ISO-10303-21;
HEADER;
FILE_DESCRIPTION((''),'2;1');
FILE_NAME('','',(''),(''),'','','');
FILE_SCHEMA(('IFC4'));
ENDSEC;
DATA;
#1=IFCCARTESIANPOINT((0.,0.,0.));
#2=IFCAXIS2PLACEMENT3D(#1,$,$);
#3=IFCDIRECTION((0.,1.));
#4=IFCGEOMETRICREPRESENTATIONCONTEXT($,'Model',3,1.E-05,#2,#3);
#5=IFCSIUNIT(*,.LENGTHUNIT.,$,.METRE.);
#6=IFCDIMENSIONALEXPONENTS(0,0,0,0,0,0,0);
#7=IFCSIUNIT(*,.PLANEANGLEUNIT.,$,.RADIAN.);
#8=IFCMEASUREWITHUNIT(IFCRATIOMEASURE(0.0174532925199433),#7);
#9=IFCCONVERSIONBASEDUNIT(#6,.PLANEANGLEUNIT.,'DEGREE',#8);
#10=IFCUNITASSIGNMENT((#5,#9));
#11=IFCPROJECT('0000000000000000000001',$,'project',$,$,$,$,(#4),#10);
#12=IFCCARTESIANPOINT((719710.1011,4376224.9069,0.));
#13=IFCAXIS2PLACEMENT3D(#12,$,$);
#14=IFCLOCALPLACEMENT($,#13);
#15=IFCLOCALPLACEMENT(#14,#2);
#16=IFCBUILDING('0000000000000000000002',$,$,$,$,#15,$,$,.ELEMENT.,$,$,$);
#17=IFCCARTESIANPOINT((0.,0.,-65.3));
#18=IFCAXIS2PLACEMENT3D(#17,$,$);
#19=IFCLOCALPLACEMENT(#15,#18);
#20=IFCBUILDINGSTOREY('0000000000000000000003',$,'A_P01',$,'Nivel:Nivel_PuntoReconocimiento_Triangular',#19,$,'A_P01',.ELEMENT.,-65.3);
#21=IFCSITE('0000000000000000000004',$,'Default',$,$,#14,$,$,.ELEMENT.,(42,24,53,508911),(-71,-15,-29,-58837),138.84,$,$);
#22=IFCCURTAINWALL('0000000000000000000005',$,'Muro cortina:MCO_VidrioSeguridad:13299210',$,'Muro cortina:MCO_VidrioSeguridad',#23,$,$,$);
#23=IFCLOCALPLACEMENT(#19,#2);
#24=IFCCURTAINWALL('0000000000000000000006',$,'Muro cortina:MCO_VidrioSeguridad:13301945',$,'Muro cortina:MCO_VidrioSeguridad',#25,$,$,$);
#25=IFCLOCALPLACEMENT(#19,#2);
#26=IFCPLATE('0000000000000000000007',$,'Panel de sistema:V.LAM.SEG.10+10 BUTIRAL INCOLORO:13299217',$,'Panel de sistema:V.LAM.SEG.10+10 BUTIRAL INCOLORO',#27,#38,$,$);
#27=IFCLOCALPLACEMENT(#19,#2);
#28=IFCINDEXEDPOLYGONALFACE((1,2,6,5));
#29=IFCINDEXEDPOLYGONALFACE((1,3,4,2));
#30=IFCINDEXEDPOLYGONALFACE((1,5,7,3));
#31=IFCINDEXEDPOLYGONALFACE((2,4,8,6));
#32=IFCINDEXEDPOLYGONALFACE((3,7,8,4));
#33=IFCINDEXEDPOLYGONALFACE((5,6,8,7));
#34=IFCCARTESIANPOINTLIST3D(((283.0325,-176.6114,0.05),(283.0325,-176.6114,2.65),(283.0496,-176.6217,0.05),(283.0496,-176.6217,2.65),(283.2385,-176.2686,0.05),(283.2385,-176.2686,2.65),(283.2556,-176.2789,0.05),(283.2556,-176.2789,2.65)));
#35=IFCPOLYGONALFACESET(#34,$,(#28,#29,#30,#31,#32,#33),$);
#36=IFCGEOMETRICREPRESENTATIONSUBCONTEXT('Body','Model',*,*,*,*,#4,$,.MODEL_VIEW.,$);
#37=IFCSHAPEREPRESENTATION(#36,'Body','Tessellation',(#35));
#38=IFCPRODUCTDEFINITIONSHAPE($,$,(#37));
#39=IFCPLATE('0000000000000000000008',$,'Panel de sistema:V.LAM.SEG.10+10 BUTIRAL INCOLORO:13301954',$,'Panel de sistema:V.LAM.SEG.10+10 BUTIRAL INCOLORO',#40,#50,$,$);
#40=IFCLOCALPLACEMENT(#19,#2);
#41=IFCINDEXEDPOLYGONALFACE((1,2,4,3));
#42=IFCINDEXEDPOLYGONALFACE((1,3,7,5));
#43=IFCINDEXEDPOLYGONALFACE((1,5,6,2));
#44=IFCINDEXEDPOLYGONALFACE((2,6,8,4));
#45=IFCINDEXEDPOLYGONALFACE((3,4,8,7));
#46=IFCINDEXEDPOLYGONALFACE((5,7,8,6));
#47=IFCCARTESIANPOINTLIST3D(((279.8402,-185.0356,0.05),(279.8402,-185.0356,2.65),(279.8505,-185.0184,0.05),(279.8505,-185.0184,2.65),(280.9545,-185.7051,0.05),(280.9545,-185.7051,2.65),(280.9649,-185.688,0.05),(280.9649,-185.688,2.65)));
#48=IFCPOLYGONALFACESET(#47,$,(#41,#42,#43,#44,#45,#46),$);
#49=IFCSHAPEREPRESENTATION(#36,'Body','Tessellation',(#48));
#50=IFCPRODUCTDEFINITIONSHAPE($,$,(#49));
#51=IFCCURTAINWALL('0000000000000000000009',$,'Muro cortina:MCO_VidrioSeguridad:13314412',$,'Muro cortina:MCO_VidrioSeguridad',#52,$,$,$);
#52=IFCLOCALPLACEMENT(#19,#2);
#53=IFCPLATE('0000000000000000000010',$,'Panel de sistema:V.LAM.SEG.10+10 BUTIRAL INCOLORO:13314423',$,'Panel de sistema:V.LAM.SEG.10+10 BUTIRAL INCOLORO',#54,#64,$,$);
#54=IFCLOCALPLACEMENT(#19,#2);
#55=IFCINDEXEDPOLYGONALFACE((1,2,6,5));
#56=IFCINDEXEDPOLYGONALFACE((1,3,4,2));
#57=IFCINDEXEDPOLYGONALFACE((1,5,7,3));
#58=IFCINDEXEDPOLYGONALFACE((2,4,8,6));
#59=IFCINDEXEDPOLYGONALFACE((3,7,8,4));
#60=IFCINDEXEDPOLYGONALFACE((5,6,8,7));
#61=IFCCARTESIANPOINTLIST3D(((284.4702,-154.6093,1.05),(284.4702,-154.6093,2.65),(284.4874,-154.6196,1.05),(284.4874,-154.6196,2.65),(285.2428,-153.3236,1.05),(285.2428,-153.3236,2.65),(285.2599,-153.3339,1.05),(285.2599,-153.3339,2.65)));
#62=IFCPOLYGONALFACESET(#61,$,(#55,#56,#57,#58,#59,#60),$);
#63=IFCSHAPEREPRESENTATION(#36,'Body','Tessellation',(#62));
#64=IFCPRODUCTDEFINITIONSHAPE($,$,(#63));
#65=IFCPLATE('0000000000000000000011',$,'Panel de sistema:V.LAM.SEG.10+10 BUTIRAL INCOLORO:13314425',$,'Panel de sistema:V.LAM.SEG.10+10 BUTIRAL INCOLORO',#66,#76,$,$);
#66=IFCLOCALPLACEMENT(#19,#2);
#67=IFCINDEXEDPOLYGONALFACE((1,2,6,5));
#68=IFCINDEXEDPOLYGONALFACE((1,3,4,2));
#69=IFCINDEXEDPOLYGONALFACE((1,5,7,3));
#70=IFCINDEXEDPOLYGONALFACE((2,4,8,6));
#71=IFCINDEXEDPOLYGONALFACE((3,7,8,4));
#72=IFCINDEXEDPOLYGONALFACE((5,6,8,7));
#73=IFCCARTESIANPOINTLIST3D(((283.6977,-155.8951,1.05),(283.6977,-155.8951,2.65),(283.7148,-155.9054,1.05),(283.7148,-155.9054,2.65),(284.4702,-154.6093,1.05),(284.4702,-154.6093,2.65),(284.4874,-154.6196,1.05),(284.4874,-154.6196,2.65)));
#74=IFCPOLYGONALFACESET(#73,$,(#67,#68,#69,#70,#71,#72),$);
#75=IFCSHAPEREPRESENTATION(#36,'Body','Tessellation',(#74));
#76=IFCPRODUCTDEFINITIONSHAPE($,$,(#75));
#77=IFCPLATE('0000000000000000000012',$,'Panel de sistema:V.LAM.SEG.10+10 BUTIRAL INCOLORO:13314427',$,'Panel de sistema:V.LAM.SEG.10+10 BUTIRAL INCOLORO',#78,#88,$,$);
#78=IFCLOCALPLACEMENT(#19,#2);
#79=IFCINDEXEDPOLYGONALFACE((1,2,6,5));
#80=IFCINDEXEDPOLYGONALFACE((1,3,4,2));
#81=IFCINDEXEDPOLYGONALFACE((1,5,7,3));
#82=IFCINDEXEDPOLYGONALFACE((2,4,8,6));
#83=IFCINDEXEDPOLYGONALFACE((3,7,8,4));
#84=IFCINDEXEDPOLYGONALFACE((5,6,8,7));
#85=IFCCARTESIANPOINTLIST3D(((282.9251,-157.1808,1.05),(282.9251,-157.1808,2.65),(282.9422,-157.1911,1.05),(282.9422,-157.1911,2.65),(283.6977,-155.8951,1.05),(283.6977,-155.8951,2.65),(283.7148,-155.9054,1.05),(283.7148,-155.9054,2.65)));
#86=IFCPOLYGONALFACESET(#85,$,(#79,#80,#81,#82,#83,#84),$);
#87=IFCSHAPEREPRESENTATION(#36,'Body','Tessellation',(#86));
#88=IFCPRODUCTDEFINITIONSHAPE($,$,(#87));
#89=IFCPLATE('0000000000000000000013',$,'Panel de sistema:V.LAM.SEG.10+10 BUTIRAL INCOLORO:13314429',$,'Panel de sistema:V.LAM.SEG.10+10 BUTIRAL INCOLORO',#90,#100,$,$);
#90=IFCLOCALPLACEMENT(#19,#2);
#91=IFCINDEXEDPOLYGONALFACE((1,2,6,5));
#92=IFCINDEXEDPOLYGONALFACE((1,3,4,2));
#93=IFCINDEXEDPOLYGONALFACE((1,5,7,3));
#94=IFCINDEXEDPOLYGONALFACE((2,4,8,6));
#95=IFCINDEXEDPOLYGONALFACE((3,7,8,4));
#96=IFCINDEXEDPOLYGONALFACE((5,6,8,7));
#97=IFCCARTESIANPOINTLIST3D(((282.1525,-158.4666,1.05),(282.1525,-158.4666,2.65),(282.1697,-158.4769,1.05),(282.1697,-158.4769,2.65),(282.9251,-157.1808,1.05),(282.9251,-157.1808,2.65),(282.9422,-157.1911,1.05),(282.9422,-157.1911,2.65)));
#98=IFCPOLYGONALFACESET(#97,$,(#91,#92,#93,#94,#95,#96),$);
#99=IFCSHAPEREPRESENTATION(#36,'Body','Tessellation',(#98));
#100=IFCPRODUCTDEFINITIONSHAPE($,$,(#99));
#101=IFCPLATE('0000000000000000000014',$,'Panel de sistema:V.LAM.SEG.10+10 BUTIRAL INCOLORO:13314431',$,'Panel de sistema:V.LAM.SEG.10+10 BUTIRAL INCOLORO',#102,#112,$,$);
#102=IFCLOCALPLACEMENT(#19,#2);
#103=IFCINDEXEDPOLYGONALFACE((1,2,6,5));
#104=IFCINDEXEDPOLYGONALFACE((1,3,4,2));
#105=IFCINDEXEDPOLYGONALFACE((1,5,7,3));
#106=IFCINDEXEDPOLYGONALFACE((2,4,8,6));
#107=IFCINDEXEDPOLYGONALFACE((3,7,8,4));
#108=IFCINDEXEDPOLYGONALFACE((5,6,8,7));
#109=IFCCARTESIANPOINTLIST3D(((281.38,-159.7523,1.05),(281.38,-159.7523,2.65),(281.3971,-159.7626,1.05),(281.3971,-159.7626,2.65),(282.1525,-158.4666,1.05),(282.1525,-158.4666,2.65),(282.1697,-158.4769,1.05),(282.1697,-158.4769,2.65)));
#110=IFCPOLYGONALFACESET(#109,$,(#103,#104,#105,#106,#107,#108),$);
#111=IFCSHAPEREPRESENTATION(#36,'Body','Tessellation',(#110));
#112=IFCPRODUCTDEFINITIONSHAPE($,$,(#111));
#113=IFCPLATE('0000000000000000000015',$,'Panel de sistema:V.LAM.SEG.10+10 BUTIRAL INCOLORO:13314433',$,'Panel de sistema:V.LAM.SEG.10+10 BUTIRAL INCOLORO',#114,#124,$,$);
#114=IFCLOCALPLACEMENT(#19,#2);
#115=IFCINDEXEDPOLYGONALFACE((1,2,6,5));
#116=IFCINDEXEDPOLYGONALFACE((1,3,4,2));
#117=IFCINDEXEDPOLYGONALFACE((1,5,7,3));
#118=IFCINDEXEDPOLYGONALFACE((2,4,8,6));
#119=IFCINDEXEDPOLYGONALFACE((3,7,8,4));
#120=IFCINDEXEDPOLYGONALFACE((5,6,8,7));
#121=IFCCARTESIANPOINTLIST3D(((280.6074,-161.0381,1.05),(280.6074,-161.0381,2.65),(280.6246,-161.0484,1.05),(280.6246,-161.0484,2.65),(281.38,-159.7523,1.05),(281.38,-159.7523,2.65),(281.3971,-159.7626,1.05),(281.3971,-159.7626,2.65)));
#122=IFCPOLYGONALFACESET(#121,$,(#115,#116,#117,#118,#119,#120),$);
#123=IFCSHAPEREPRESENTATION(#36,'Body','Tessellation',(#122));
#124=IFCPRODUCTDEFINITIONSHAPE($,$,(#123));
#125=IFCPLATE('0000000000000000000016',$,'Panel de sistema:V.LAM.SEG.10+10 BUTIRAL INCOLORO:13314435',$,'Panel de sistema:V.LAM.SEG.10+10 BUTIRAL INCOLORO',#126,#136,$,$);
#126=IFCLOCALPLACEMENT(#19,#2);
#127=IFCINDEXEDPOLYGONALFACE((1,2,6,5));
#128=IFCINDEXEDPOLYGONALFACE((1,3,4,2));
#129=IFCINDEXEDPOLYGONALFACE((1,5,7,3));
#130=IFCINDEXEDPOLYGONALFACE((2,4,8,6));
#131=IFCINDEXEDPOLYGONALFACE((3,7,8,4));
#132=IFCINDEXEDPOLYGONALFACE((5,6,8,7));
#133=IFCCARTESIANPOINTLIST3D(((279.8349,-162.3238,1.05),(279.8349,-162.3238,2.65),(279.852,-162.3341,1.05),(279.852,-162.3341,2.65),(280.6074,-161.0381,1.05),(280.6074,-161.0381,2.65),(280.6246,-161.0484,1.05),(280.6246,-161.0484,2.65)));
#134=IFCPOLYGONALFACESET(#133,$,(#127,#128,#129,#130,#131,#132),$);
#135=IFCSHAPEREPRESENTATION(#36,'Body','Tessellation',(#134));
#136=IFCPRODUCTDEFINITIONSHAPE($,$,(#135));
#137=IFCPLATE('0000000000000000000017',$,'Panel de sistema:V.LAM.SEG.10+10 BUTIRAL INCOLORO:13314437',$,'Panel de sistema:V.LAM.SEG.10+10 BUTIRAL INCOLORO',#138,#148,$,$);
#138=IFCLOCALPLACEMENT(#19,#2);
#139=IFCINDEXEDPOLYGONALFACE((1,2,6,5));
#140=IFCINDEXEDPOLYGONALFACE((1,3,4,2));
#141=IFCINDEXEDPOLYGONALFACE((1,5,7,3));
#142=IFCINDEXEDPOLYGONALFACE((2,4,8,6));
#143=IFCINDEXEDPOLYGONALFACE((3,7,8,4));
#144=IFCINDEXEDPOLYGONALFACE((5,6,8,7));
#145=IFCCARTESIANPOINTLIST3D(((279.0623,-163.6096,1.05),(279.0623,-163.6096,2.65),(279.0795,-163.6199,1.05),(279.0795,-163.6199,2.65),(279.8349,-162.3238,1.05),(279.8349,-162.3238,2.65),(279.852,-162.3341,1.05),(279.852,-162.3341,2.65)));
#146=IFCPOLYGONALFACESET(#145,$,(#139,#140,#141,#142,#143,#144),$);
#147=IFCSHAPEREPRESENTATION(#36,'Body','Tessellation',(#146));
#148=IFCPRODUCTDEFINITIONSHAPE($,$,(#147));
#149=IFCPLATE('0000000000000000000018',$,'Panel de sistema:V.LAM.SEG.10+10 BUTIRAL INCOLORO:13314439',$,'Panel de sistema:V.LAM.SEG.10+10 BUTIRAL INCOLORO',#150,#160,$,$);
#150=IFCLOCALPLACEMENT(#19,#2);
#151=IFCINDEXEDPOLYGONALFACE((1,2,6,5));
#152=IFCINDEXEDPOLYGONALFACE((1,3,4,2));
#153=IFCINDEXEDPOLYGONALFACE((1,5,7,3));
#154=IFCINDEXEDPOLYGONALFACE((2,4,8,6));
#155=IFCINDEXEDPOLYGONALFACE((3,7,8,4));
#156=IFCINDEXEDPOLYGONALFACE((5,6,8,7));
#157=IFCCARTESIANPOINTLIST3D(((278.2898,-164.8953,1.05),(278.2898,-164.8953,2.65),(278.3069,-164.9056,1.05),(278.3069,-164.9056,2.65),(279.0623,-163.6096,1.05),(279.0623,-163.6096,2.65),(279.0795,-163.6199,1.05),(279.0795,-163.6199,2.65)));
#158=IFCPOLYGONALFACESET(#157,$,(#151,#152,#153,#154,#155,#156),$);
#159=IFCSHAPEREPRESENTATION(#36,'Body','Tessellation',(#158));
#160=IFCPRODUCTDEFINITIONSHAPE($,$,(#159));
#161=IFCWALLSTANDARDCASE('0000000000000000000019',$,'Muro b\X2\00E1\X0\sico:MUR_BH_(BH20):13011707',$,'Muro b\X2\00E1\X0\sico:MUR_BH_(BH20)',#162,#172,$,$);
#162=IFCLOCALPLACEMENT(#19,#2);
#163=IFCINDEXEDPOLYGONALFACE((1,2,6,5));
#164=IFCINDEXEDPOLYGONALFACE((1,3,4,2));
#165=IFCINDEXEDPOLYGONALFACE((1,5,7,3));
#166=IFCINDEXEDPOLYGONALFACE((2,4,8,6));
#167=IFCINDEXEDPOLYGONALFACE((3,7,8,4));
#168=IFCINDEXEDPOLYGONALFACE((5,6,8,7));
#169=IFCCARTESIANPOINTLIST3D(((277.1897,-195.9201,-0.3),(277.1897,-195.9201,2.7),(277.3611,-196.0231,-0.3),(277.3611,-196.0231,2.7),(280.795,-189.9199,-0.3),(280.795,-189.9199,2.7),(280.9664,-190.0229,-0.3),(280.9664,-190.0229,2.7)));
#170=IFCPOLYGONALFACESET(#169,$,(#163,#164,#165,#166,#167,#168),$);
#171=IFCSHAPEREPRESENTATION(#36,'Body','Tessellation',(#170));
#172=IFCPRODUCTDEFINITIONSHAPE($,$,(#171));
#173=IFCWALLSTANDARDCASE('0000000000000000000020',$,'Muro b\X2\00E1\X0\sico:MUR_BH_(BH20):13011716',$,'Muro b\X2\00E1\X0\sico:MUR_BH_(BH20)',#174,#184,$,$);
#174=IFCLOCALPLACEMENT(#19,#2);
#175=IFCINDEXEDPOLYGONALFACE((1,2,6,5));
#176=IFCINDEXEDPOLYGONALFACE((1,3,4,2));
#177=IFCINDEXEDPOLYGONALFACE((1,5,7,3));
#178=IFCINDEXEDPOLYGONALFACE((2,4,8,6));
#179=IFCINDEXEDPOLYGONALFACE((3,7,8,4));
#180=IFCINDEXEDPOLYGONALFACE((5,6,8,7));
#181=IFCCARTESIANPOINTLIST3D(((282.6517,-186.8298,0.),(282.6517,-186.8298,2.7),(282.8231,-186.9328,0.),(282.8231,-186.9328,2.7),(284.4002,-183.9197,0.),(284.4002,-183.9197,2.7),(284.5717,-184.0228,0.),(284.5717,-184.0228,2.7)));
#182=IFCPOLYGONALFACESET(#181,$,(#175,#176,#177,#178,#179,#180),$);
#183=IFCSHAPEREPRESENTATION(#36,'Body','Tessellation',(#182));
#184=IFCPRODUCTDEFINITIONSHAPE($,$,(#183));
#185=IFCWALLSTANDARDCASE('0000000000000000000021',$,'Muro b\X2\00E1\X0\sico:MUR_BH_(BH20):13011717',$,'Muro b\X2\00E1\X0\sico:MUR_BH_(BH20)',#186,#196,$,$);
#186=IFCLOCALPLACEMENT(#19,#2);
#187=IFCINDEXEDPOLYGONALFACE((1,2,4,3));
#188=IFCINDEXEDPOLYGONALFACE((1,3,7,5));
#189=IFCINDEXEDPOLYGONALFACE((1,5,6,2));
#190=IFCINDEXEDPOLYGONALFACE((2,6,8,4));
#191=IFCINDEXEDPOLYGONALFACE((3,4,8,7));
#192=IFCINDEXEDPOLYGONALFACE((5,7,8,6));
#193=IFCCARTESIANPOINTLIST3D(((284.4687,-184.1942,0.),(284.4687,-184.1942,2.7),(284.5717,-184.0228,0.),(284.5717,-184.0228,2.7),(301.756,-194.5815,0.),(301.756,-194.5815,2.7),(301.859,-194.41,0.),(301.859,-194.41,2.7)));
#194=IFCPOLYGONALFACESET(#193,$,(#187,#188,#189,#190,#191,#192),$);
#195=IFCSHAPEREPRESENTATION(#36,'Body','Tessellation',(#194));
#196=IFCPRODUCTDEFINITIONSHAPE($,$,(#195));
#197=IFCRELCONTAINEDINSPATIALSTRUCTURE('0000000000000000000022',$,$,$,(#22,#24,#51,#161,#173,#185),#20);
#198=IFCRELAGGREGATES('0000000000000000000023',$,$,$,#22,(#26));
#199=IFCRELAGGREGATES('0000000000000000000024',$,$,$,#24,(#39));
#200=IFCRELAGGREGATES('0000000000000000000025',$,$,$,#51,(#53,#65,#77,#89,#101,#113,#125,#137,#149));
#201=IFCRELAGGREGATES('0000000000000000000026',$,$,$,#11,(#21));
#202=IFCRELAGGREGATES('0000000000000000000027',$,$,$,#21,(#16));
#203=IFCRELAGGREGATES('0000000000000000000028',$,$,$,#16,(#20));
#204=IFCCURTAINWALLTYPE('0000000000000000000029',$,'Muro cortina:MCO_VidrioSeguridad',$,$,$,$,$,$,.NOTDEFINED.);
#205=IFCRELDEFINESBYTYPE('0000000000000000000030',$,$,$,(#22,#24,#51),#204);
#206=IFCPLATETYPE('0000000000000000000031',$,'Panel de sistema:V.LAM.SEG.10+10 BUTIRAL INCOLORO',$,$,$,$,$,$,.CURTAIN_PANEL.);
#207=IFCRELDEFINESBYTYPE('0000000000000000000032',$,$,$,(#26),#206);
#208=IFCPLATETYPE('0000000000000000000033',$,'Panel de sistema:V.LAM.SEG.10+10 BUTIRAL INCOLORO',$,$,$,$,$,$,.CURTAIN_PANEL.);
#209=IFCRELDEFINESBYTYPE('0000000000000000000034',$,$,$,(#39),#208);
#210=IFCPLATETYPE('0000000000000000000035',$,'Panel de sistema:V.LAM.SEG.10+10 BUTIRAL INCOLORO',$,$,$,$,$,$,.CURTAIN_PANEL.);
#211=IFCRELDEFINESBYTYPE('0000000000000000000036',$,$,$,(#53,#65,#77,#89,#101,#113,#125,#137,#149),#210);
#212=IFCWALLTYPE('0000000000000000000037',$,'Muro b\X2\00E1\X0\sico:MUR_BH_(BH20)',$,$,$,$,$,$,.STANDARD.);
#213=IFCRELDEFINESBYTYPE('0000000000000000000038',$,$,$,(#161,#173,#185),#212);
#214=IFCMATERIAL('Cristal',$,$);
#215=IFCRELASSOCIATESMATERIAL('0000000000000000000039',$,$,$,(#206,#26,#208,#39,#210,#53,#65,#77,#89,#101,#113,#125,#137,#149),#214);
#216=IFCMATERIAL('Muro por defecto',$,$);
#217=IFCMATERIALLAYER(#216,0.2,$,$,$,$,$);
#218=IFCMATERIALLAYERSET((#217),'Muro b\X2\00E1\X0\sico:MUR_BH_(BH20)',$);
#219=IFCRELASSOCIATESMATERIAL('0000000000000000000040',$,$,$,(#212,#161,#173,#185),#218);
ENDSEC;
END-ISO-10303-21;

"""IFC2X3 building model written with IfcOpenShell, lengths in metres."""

from ifc_helpers import new_model, entity, si_unit, converted_unit, direction, frame, frame_2d, origin, origin_2d_with_axis, place, context, subcontext, project, spatial, rectangle, extrude, source, transform, mapped, material, layer, layer_set, layer_usage, type_object, type_shapes, element, aggregate, save


model = new_model("IFC2X3")

# Units and contexts
model_context = context("Model", 3, precision=1e-05, world=origin(), true_north=direction((0.0, 1.0)))
body_context = subcontext(model_context, "Body", "Model", "MODEL_VIEW")
ifc_project = project(units=[si_unit("LENGTHUNIT", "METRE"), converted_unit("PLANEANGLEUNIT", "DEGREE", entity("IfcRatioMeasure", 0.0174532925199433), si_unit("PLANEANGLEUNIT", "RADIAN"), dimensions=[0, 0, 0, 0, 0, 0, 0])], contexts=[model_context])

# Site, building, storey
site_placement = place(None, frame((719710.1011, 4376224.9069, 0.0)))
site = spatial("IfcSite", under=ifc_project, at=site_placement, Name="Default", CompositionType="ELEMENT", RefLatitude=(42, 24, 53, 508911), RefLongitude=(-71, -15, -29, -58837), RefElevation=138.84)
building_placement = place(site_placement, origin())
building = spatial("IfcBuilding", under=site, at=building_placement, CompositionType="ELEMENT")
storey_placement = place(building_placement, frame((0.0, 0.0, -65.3)))
storey = spatial("IfcBuildingStorey", under=building, at=storey_placement, Name="A_P01", ObjectType="Nivel:Nivel_PuntoReconocimiento_Triangular", LongName="A_P01", CompositionType="ELEMENT", Elevation=-65.3)

# Shared definitions
curtain_wall_type = type_object("IfcCurtainWallType", Name="Muro cortina:MCO_VidrioSeguridad", PredefinedType="NOTDEFINED")
ifc_material_1 = material(Name="Cristal")

# Curtain walls
curtain_wall_1_placement = place(storey_placement, frame((0.0, 0.0, 65.3)))
curtain_wall_1 = element("IfcCurtainWall", 1, at=curtain_wall_1_placement, inside=storey, type_object=curtain_wall_type, Name="Muro cortina:MCO_VidrioSeguridad:13299210", ObjectType="Muro cortina:MCO_VidrioSeguridad")
curtain_wall_2_placement = place(storey_placement, frame((0.0, 0.0, 65.3)))
curtain_wall_2 = element("IfcCurtainWall", 2, at=curtain_wall_2_placement, inside=storey, type_object=curtain_wall_type, Name="Muro cortina:MCO_VidrioSeguridad:13301945", ObjectType="Muro cortina:MCO_VidrioSeguridad")

# Plates
plate_type_1 = type_object("IfcPlateType", Name="Panel de sistema:V.LAM.SEG.10+10 BUTIRAL INCOLORO", PredefinedType="CURTAIN_PANEL", material=ifc_material_1)
shared_shape_1 = source(origin(), body_context, "Body", "SweptSolid", [
    extrude(rectangle(XDim=0.02, YDim=0.4, at=origin_2d_with_axis()), frame((0.0, 0.0, 0.0), z_axis=(0.0, 0.0, 1.0), x_axis=(0.0, 1.0, 0.0)), (0.0, 0.0, 1.0), 2.6),
])
type_shapes(plate_type_1, [shared_shape_1])
plate_1_placement = place(curtain_wall_1_placement, frame((283.1441, -176.4452, -65.25), z_axis=(0.0, 0.0, 1.0), x_axis=(0.515038, 0.857167, 0.0)))
plate_1 = element("IfcPlate", 3, at=plate_1_placement, type_object=plate_type_1, material=ifc_material_1, Name="Panel de sistema:V.LAM.SEG.10+10 BUTIRAL INCOLORO:13299217", ObjectType="Panel de sistema:V.LAM.SEG.10+10 BUTIRAL INCOLORO", context=body_context, shape_type="MappedRepresentation", body=[
    mapped(shared_shape_1, transform((0.0, 0.0, 0.0), scale=1.0)),
])
aggregate(curtain_wall_1, [plate_1])
plate_type_2 = type_object("IfcPlateType", Name="Panel de sistema:V.LAM.SEG.10+10 BUTIRAL INCOLORO", PredefinedType="CURTAIN_PANEL", material=ifc_material_1)
shared_shape_2 = source(origin(), body_context, "Body", "SweptSolid", [
    extrude(rectangle(XDim=0.02, YDim=1.3, at=origin_2d_with_axis()), frame((0.0, 0.0, 0.0), z_axis=(0.0, 0.0, 1.0), x_axis=(0.0, 1.0, 0.0)), (0.0, 0.0, 1.0), 2.6),
])
type_shapes(plate_type_2, [shared_shape_2])
plate_2_placement = place(curtain_wall_2_placement, frame((280.4025, -185.3618, -65.25), z_axis=(0.0, 0.0, 1.0), x_axis=(0.857167, -0.515038, 0.0)))
plate_2 = element("IfcPlate", 4, at=plate_2_placement, type_object=plate_type_2, material=ifc_material_1, Name="Panel de sistema:V.LAM.SEG.10+10 BUTIRAL INCOLORO:13301954", ObjectType="Panel de sistema:V.LAM.SEG.10+10 BUTIRAL INCOLORO", context=body_context, shape_type="MappedRepresentation", body=[
    mapped(shared_shape_2, transform((0.0, 0.0, 0.0), scale=1.0)),
])
aggregate(curtain_wall_2, [plate_2])

# Curtain wall, plates
curtain_wall_3_placement = place(storey_placement, frame((0.0, 0.0, 65.3)))
curtain_wall_3 = element("IfcCurtainWall", 5, at=curtain_wall_3_placement, inside=storey, type_object=curtain_wall_type, Name="Muro cortina:MCO_VidrioSeguridad:13314412", ObjectType="Muro cortina:MCO_VidrioSeguridad")
plate_type_3 = type_object("IfcPlateType", Name="Panel de sistema:V.LAM.SEG.10+10 BUTIRAL INCOLORO", PredefinedType="CURTAIN_PANEL", material=ifc_material_1)
shared_shape_3 = source(origin(), body_context, "Body", "SweptSolid", [
    extrude(rectangle(XDim=0.02, YDim=1.5, at=frame_2d((0.0, 0.0), x_axis=(1.0, 0.0))), frame((0.0, 0.0, 0.0), z_axis=(0.0, 0.0, 1.0), x_axis=(0.0, 1.0, 0.0)), (0.0, 0.0, 1.0), 1.6),
])
type_shapes(plate_type_3, [shared_shape_3])
plate_3_placement = place(curtain_wall_3_placement, frame((284.8651, -153.9716, -64.25), z_axis=(0.0, 0.0, 1.0), x_axis=(-0.515038, -0.857167, 0.0)))
plate_3 = element("IfcPlate", 6, at=plate_3_placement, type_object=plate_type_3, material=ifc_material_1, Name="Panel de sistema:V.LAM.SEG.10+10 BUTIRAL INCOLORO:13314423", ObjectType="Panel de sistema:V.LAM.SEG.10+10 BUTIRAL INCOLORO", context=body_context, shape_type="MappedRepresentation", body=[
    mapped(shared_shape_3, transform((0.0, 0.0, 0.0), scale=1.0)),
])
plate_4_placement = place(curtain_wall_3_placement, frame((284.0925, -155.2573, -64.25), z_axis=(0.0, 0.0, 1.0), x_axis=(-0.515038, -0.857167, 0.0)))
plate_4 = element("IfcPlate", 7, at=plate_4_placement, type_object=plate_type_3, material=ifc_material_1, Name="Panel de sistema:V.LAM.SEG.10+10 BUTIRAL INCOLORO:13314425", ObjectType="Panel de sistema:V.LAM.SEG.10+10 BUTIRAL INCOLORO", context=body_context, shape_type="MappedRepresentation", body=[
    mapped(shared_shape_3, transform((0.0, 0.0, 0.0), scale=1.0)),
])
plate_5_placement = place(curtain_wall_3_placement, frame((283.32, -156.5431, -64.25), z_axis=(0.0, 0.0, 1.0), x_axis=(-0.515038, -0.857167, 0.0)))
plate_5 = element("IfcPlate", 8, at=plate_5_placement, type_object=plate_type_3, material=ifc_material_1, Name="Panel de sistema:V.LAM.SEG.10+10 BUTIRAL INCOLORO:13314427", ObjectType="Panel de sistema:V.LAM.SEG.10+10 BUTIRAL INCOLORO", context=body_context, shape_type="MappedRepresentation", body=[
    mapped(shared_shape_3, transform((0.0, 0.0, 0.0), scale=1.0)),
])
plate_6_placement = place(curtain_wall_3_placement, frame((282.5474, -157.8288, -64.25), z_axis=(0.0, 0.0, 1.0), x_axis=(-0.515038, -0.857167, 0.0)))
plate_6 = element("IfcPlate", 9, at=plate_6_placement, type_object=plate_type_3, material=ifc_material_1, Name="Panel de sistema:V.LAM.SEG.10+10 BUTIRAL INCOLORO:13314429", ObjectType="Panel de sistema:V.LAM.SEG.10+10 BUTIRAL INCOLORO", context=body_context, shape_type="MappedRepresentation", body=[
    mapped(shared_shape_3, transform((0.0, 0.0, 0.0), scale=1.0)),
])
plate_7_placement = place(curtain_wall_3_placement, frame((281.7748, -159.1146, -64.25), z_axis=(0.0, 0.0, 1.0), x_axis=(-0.515038, -0.857167, 0.0)))
plate_7 = element("IfcPlate", 10, at=plate_7_placement, type_object=plate_type_3, material=ifc_material_1, Name="Panel de sistema:V.LAM.SEG.10+10 BUTIRAL INCOLORO:13314431", ObjectType="Panel de sistema:V.LAM.SEG.10+10 BUTIRAL INCOLORO", context=body_context, shape_type="MappedRepresentation", body=[
    mapped(shared_shape_3, transform((0.0, 0.0, 0.0), scale=1.0)),
])
plate_8_placement = place(curtain_wall_3_placement, frame((281.0023, -160.4003, -64.25), z_axis=(0.0, 0.0, 1.0), x_axis=(-0.515038, -0.857167, 0.0)))
plate_8 = element("IfcPlate", 11, at=plate_8_placement, type_object=plate_type_3, material=ifc_material_1, Name="Panel de sistema:V.LAM.SEG.10+10 BUTIRAL INCOLORO:13314433", ObjectType="Panel de sistema:V.LAM.SEG.10+10 BUTIRAL INCOLORO", context=body_context, shape_type="MappedRepresentation", body=[
    mapped(shared_shape_3, transform((0.0, 0.0, 0.0), scale=1.0)),
])
plate_9_placement = place(curtain_wall_3_placement, frame((280.2297, -161.6861, -64.25), z_axis=(0.0, 0.0, 1.0), x_axis=(-0.515038, -0.857167, 0.0)))
plate_9 = element("IfcPlate", 12, at=plate_9_placement, type_object=plate_type_3, material=ifc_material_1, Name="Panel de sistema:V.LAM.SEG.10+10 BUTIRAL INCOLORO:13314435", ObjectType="Panel de sistema:V.LAM.SEG.10+10 BUTIRAL INCOLORO", context=body_context, shape_type="MappedRepresentation", body=[
    mapped(shared_shape_3, transform((0.0, 0.0, 0.0), scale=1.0)),
])
plate_10_placement = place(curtain_wall_3_placement, frame((279.4572, -162.9718, -64.25), z_axis=(0.0, 0.0, 1.0), x_axis=(-0.515038, -0.857167, 0.0)))
plate_10 = element("IfcPlate", 13, at=plate_10_placement, type_object=plate_type_3, material=ifc_material_1, Name="Panel de sistema:V.LAM.SEG.10+10 BUTIRAL INCOLORO:13314437", ObjectType="Panel de sistema:V.LAM.SEG.10+10 BUTIRAL INCOLORO", context=body_context, shape_type="MappedRepresentation", body=[
    mapped(shared_shape_3, transform((0.0, 0.0, 0.0), scale=1.0)),
])
plate_11_placement = place(curtain_wall_3_placement, frame((278.6846, -164.2576, -64.25), z_axis=(0.0, 0.0, 1.0), x_axis=(-0.515038, -0.857167, 0.0)))
plate_11 = element("IfcPlate", 14, at=plate_11_placement, type_object=plate_type_3, material=ifc_material_1, Name="Panel de sistema:V.LAM.SEG.10+10 BUTIRAL INCOLORO:13314439", ObjectType="Panel de sistema:V.LAM.SEG.10+10 BUTIRAL INCOLORO", context=body_context, shape_type="MappedRepresentation", body=[
    mapped(shared_shape_3, transform((0.0, 0.0, 0.0), scale=1.0)),
])
aggregate(curtain_wall_3, [plate_3, plate_4, plate_5, plate_6, plate_7, plate_8, plate_9, plate_10, plate_11])

# Walls
ifc_material_2 = material(Name="Muro por defecto")
ifc_layer_1 = layer(ifc_material_2, 0.2)
ifc_layer_set_1 = layer_set([ifc_layer_1], Name="Muro básico:MUR_BH_(BH20)")
ifc_layer_usage_1 = layer_usage(ifc_layer_set_1, "AXIS2", "NEGATIVE", 0.1)
wall_type_1 = type_object("IfcWallType", Name="Muro básico:MUR_BH_(BH20)", PredefinedType="STANDARD", material=ifc_layer_set_1)
wall_1_placement = place(storey_placement, frame((280.8807, -189.9714, -0.3), z_axis=(0.0, 0.0, 1.0), x_axis=(-0.515038, -0.857167, 0.0)))
element("IfcWallStandardCase", 15, at=wall_1_placement, inside=storey, type_object=wall_type_1, material=ifc_layer_usage_1, Name="Muro básico:MUR_BH_(BH20):13011707", ObjectType="Muro básico:MUR_BH_(BH20)", context=body_context, shape_type="SweptSolid", body=[
    extrude(rectangle(XDim=7.0, YDim=0.2, at=frame_2d((3.5, 0.0), x_axis=(-1.0, 0.0))), origin(), (0.0, 0.0, 1.0), 3.0),
])
ifc_layer_usage_2 = layer_usage(ifc_layer_set_1, "AXIS2", "NEGATIVE", 0.1)
wall_2_placement = place(storey_placement, frame((282.7374, -186.8813, 0.0), z_axis=(0.0, 0.0, 1.0), x_axis=(0.515038, 0.857167, 0.0)))
element("IfcWallStandardCase", 16, at=wall_2_placement, inside=storey, type_object=wall_type_1, material=ifc_layer_usage_2, Name="Muro básico:MUR_BH_(BH20):13011716", ObjectType="Muro básico:MUR_BH_(BH20)", context=body_context, shape_type="SweptSolid", body=[
    extrude(rectangle(XDim=3.395, YDim=0.2, at=frame_2d((1.6975, 0.0), x_axis=(-1.0, 0.0))), origin(), (0.0, 0.0, 1.0), 2.7),
])
ifc_layer_usage_3 = layer_usage(ifc_layer_set_1, "AXIS2", "NEGATIVE", 0.1)
wall_3_placement = place(storey_placement, frame((284.5202, -184.1085, 0.0), z_axis=(0.0, 0.0, 1.0), x_axis=(0.857167, -0.515038, 0.0)))
element("IfcWallStandardCase", 17, at=wall_3_placement, inside=storey, type_object=wall_type_1, material=ifc_layer_usage_3, Name="Muro básico:MUR_BH_(BH20):13011717", ObjectType="Muro básico:MUR_BH_(BH20)", context=body_context, shape_type="SweptSolid", body=[
    extrude(rectangle(XDim=20.168, YDim=0.2, at=frame_2d((10.084, 0.0), x_axis=(-1.0, 0.0))), origin(), (0.0, 0.0, 1.0), 2.7),
])

save(model, "model.ifc")
